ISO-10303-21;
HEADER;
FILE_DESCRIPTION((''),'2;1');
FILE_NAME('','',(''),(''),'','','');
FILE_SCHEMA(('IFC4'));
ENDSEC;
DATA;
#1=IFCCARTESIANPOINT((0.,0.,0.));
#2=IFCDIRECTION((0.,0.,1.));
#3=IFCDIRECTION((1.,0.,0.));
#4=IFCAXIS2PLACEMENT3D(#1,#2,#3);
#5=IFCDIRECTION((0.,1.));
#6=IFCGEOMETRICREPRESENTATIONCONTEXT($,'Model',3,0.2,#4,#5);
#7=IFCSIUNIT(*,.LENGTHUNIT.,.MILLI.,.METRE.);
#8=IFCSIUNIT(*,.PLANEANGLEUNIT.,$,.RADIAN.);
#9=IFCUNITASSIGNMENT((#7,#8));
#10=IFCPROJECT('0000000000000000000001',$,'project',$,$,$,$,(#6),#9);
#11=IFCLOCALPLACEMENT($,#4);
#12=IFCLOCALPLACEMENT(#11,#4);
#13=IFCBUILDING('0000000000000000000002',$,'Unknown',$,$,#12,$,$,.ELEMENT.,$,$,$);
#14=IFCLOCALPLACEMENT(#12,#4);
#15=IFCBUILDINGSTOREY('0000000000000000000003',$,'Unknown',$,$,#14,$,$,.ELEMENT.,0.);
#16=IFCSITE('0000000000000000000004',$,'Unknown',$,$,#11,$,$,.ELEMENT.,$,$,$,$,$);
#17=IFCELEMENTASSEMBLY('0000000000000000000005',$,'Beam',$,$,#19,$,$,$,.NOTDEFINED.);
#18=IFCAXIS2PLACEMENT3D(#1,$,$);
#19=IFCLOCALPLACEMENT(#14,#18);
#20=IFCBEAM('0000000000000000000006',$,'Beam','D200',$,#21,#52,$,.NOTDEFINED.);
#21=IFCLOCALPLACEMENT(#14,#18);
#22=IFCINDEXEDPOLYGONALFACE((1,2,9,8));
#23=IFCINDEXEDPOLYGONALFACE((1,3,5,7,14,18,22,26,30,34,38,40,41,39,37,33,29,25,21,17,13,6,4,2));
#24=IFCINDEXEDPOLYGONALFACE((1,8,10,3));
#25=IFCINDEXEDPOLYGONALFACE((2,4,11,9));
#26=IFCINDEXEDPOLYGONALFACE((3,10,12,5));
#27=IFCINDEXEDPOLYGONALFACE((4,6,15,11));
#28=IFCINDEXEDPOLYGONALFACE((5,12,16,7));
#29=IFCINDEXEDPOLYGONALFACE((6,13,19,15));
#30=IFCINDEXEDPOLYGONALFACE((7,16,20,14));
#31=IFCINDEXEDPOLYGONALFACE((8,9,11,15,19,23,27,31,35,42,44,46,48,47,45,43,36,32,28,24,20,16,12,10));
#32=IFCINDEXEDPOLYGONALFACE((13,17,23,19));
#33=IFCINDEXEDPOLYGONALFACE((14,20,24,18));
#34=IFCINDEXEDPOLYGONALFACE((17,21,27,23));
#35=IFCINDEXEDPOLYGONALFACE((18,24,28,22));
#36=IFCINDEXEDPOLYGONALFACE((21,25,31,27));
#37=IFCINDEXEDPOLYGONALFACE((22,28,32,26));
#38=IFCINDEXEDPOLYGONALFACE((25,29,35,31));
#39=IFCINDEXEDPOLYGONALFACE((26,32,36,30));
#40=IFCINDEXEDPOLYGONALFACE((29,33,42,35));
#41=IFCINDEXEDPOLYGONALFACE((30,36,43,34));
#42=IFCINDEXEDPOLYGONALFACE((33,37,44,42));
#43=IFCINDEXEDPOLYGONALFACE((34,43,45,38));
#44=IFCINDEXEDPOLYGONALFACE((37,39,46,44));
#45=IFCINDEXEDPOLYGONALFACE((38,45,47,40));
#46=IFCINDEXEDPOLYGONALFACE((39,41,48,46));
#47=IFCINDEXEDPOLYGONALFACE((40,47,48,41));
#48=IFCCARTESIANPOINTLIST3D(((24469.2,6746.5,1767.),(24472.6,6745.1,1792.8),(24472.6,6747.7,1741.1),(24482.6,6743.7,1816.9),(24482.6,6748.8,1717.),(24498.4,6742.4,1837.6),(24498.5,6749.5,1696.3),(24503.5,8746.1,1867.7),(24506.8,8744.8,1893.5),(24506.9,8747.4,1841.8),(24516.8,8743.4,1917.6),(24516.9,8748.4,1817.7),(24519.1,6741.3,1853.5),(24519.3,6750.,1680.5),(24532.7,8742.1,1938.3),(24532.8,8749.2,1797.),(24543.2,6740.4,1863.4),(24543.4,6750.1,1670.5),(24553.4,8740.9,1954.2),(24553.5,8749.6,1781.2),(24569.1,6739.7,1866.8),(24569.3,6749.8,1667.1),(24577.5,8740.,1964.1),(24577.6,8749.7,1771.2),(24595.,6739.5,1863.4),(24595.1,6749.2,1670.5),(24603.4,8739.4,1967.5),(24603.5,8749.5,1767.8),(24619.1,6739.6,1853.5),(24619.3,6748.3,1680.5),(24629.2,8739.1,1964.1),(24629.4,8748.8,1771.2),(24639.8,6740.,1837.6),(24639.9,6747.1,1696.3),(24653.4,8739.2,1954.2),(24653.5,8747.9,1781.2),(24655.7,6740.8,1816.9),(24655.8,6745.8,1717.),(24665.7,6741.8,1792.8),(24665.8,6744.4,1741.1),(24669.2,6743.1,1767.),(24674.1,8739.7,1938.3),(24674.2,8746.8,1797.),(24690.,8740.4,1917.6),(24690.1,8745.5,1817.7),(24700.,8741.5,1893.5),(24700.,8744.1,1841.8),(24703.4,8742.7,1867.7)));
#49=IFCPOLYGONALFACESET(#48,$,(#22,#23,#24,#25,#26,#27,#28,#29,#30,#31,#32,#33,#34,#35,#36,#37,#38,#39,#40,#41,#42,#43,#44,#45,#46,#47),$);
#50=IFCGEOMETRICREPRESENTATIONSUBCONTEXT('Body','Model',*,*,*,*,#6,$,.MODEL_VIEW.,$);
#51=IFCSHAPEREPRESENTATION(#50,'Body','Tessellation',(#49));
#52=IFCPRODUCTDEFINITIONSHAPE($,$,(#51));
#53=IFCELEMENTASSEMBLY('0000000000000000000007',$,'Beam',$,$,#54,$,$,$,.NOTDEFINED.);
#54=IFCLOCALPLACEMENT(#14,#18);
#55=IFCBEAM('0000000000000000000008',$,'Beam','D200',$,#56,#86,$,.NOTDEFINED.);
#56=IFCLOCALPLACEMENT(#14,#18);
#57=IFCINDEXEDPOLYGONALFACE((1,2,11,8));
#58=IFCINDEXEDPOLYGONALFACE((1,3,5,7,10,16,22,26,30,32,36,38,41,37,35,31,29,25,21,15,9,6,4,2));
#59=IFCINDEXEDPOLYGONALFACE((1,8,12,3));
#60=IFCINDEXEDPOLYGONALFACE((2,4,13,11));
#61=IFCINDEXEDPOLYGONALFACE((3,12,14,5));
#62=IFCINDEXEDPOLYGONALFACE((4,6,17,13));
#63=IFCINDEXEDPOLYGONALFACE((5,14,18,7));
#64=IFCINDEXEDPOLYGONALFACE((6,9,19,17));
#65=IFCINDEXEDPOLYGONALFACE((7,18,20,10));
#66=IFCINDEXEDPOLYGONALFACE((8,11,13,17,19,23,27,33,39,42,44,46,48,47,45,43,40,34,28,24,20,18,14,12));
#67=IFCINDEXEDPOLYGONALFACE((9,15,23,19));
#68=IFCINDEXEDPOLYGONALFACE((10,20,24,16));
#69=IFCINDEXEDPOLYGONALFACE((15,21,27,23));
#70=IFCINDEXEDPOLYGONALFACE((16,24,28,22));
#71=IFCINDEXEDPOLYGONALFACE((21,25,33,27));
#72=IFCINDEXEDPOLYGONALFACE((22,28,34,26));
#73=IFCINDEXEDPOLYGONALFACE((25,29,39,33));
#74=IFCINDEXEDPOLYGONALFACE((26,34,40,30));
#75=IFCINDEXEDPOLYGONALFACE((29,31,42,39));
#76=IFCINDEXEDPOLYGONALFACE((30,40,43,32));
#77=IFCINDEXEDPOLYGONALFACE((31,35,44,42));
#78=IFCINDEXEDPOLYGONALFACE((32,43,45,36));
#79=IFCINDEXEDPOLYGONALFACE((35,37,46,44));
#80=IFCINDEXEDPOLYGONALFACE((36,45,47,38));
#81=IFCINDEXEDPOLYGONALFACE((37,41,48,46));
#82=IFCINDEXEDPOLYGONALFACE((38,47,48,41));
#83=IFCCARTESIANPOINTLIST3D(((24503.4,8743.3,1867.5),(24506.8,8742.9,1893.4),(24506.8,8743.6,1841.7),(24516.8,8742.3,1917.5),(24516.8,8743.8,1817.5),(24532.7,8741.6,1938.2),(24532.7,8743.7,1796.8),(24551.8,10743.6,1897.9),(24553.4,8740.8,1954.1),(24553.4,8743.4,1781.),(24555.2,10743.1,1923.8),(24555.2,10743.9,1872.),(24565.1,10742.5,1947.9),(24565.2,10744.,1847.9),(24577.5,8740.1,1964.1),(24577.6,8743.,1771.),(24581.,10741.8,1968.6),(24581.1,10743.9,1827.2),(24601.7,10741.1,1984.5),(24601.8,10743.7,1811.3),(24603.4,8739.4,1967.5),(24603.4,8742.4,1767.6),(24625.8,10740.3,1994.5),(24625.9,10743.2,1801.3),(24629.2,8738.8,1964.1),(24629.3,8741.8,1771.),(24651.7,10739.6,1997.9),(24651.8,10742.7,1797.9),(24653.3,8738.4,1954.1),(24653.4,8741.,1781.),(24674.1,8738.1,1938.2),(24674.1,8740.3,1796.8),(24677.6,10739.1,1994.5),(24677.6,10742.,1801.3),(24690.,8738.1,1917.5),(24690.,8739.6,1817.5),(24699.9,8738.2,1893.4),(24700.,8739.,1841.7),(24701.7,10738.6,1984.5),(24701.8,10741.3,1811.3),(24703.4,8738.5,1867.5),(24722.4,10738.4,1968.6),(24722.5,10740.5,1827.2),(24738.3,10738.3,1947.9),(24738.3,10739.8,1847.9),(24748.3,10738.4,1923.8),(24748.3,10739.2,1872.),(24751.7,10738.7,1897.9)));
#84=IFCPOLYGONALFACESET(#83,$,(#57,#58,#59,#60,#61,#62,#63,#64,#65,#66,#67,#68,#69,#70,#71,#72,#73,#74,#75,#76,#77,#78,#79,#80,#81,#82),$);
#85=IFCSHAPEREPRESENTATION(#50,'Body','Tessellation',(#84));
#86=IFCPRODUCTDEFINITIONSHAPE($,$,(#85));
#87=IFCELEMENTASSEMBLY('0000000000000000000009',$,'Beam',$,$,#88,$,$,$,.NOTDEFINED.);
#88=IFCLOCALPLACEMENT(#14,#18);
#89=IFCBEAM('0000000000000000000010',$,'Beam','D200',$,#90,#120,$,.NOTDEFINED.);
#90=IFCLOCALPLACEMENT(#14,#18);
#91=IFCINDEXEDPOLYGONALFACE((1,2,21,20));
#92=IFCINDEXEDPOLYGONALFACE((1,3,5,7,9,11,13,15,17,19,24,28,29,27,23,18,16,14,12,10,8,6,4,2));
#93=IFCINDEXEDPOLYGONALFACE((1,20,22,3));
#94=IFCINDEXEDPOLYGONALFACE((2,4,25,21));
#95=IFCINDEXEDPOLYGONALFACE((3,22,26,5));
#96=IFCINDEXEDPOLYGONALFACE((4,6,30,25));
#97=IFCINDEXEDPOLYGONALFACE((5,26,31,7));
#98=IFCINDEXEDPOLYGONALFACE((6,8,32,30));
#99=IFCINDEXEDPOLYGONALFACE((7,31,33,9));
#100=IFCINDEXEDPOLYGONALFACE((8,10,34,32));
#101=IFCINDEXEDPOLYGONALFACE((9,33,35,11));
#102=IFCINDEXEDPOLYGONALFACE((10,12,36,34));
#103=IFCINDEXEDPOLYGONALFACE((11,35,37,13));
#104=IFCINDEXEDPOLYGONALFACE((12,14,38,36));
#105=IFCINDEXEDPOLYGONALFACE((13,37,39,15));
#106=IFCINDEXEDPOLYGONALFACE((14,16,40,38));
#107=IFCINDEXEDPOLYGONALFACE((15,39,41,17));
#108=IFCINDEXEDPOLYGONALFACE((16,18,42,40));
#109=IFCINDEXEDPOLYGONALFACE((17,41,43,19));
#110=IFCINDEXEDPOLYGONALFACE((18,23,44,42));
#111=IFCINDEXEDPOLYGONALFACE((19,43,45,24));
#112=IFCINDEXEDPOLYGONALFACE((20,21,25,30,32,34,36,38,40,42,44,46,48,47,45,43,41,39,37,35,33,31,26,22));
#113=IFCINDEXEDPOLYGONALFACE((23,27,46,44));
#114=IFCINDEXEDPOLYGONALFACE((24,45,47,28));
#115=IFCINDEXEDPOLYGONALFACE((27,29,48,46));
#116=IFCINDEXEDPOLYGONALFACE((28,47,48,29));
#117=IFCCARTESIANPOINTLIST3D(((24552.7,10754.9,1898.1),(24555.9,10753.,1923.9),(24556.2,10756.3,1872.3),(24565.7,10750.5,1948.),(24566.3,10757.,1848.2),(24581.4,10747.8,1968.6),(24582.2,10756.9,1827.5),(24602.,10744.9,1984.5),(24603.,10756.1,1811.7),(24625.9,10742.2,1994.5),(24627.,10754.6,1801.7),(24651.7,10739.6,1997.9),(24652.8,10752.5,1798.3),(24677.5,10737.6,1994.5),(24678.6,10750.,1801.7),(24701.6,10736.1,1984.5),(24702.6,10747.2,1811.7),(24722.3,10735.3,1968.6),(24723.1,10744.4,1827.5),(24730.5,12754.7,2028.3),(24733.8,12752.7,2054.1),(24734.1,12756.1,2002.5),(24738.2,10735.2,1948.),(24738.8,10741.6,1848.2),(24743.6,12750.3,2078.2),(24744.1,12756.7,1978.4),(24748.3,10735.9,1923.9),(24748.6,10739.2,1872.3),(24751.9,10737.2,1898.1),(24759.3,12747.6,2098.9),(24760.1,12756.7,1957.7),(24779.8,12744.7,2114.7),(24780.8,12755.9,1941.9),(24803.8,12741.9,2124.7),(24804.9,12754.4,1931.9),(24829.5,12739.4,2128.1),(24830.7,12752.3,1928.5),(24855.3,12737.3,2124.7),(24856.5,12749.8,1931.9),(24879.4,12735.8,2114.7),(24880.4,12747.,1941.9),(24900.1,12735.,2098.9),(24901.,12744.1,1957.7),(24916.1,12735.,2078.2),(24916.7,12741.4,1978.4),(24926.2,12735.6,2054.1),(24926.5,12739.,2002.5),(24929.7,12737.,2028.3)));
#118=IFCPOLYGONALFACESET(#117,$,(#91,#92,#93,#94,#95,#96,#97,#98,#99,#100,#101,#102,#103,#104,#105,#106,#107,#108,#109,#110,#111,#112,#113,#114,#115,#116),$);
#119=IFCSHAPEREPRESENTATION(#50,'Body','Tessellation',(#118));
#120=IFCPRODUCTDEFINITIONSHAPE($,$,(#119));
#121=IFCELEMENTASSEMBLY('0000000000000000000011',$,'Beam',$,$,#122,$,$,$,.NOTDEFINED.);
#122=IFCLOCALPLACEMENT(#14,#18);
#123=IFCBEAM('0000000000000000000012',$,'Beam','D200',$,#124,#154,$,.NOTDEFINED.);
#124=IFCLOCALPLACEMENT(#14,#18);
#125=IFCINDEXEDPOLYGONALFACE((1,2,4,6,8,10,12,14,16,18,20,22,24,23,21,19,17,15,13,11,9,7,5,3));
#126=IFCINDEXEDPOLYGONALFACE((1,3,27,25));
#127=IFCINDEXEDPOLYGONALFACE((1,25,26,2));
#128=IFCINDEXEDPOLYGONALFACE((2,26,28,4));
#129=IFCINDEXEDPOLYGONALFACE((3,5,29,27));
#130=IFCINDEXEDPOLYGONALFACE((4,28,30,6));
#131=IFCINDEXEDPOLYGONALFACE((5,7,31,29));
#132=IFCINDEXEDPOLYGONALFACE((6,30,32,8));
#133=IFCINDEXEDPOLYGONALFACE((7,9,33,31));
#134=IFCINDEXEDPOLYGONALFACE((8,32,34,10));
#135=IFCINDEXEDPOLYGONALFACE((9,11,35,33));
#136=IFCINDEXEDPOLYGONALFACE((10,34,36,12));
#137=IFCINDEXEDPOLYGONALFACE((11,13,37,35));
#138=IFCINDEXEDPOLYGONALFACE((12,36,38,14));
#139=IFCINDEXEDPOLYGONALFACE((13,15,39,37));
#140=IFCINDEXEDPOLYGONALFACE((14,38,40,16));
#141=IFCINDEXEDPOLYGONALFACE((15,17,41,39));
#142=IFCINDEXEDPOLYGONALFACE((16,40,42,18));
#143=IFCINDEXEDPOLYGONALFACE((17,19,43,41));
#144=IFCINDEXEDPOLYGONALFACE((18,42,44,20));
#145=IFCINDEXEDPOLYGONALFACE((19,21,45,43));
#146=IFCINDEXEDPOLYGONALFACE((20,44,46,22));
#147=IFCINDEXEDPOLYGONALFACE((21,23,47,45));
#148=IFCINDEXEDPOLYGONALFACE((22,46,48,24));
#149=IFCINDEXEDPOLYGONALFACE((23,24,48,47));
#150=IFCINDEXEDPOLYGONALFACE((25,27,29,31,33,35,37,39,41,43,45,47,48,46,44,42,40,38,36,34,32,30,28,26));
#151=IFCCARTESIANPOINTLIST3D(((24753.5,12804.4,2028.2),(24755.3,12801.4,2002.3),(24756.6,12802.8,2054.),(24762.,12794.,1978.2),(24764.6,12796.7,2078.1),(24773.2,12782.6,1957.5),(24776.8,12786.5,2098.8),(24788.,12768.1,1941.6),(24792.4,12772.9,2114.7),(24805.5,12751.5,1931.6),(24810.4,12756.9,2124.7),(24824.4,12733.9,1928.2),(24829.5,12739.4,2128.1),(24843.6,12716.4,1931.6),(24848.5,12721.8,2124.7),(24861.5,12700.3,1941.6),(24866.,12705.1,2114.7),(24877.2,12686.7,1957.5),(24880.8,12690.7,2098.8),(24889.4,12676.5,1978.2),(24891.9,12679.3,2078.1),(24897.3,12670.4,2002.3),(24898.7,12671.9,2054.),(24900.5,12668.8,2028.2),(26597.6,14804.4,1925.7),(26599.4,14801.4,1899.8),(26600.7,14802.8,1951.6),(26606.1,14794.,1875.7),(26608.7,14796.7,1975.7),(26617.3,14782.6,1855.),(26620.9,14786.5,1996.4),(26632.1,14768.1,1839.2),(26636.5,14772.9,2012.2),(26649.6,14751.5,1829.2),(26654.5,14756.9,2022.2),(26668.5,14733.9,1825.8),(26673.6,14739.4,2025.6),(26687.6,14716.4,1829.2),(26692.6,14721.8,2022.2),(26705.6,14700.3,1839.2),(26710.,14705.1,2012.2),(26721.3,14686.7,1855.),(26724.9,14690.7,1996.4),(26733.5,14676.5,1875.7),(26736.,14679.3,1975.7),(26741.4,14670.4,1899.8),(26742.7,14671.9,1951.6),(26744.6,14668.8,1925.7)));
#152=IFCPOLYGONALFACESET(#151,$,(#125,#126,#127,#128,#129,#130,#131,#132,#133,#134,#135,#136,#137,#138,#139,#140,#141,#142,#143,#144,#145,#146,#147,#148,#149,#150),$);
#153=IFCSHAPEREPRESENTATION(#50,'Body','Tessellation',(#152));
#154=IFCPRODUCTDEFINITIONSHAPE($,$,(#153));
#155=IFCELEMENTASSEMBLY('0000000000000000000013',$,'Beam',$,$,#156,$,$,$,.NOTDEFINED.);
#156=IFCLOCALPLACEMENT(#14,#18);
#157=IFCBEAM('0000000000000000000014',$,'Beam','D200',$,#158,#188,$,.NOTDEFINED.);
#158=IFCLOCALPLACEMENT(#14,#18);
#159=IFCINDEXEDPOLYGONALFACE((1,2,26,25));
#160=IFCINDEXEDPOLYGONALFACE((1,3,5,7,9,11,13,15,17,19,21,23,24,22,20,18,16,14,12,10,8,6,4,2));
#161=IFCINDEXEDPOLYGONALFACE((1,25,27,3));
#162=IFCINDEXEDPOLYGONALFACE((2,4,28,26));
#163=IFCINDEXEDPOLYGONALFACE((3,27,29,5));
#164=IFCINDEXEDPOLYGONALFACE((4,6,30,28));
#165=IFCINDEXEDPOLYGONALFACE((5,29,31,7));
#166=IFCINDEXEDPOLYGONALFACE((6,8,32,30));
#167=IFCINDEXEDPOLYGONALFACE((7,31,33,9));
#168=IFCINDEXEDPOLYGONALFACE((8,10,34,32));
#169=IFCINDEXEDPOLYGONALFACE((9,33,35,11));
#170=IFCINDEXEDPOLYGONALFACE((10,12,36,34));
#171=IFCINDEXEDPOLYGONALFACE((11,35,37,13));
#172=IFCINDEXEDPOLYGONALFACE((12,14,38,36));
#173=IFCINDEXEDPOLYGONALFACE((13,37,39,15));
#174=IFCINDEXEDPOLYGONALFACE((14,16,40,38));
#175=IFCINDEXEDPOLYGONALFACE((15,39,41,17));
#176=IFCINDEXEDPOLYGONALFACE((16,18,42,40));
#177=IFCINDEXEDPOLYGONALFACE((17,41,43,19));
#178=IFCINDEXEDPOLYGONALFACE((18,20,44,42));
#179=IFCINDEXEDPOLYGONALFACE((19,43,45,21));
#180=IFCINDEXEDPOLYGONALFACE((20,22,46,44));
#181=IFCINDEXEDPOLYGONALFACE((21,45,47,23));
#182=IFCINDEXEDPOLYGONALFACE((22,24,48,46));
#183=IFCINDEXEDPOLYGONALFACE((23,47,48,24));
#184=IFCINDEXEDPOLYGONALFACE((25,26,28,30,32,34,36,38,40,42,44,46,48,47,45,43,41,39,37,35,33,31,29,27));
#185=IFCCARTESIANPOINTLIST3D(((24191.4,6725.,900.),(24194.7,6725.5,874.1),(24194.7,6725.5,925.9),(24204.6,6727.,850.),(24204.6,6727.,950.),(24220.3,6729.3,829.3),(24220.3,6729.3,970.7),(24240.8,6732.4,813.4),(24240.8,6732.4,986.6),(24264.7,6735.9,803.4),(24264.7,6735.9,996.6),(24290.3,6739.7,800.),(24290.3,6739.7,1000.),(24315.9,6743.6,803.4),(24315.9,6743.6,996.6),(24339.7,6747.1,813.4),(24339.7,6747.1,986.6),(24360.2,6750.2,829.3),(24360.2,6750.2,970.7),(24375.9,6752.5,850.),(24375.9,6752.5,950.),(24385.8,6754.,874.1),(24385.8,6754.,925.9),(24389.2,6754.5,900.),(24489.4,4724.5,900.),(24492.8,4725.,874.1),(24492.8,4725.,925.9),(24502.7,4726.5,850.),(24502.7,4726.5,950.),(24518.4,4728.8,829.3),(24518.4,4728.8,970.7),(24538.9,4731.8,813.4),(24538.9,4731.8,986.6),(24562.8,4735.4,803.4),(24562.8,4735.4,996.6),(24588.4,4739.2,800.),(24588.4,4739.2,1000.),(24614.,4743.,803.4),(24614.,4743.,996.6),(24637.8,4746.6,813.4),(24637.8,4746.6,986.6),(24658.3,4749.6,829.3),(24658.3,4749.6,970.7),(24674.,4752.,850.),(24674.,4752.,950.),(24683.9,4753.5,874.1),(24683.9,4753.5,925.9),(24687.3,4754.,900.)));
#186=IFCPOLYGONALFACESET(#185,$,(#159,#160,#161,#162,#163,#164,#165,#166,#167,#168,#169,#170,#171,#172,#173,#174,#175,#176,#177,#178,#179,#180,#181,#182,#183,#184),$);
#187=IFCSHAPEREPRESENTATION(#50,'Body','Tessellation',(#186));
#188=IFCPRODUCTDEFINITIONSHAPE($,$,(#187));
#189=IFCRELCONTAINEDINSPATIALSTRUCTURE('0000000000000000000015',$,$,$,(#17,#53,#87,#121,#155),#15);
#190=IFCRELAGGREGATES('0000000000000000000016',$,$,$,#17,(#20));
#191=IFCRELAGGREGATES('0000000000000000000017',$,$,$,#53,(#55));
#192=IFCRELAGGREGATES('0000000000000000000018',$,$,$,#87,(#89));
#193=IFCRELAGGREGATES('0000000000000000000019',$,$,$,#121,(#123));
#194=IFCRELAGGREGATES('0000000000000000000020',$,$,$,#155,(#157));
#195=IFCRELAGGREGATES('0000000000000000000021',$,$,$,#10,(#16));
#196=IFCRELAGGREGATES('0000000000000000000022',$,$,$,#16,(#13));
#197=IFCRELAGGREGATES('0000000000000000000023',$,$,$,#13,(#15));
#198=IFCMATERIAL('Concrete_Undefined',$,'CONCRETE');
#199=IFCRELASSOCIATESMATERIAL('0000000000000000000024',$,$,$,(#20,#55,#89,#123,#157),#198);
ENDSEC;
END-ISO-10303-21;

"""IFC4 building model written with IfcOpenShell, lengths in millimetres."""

from ifc_helpers import new_model, si_unit, direction, frame, origin_with_axes, place, context, subcontext, project, spatial, line, indexed_curve, outline, extrude, material, element, aggregate, save


model = new_model("IFC4")

# Units and contexts
model_context = context("Model", 3, precision=0.2, world=origin_with_axes(), true_north=direction((0.0, 1.0)))
body_context = subcontext(model_context, "Body", "Model", "MODEL_VIEW")
ifc_project = project(units=[si_unit("LENGTHUNIT", "METRE", prefix="MILLI"), si_unit("PLANEANGLEUNIT", "RADIAN")], contexts=[model_context])

# Site, building, storey
site_placement = place(None, origin_with_axes())
site = spatial("IfcSite", under=ifc_project, at=site_placement, Name="Unknown", CompositionType="ELEMENT")
building_placement = place(site_placement, origin_with_axes())
building = spatial("IfcBuilding", under=site, at=building_placement, Name="Unknown", CompositionType="ELEMENT")
storey_placement = place(building_placement, origin_with_axes())
storey = spatial("IfcBuildingStorey", under=building, at=storey_placement, Name="Unknown", CompositionType="ELEMENT", Elevation=0.0)

# Shared definitions
ifc_material = material(Name="Concrete_Undefined", Category="CONCRETE")

# Element assemblies, beams
assembly_1_placement = place(storey_placement, frame((24603.4, 8744.4, 1867.7), z_axis=(-0.999853, 0.01713, 0.0), x_axis=(-0.017108, -0.998588, -0.050282)))
assembly_1 = element("IfcElementAssembly", 1, at=assembly_1_placement, inside=storey, Name="Beam", PredefinedType="NOTDEFINED")
beam_1_placement = place(assembly_1_placement, origin_with_axes())
beam_1 = element("IfcBeam", 2, at=beam_1_placement, material=ifc_material, Name="Beam", Description="D200", PredefinedType="NOTDEFINED", context=body_context, shape_type="SolidModel", body=[
    extrude(outline(indexed_curve([(100.0, 0.0), (96.6, 25.9), (86.6, 50.0), (70.7, 70.7), (50.0, 86.6), (25.9, 96.6), (0.0, 100.0), (-25.9, 96.6), (-50.0, 86.6), (-70.7, 70.7), (-86.6, 50.0), (-96.6, 25.9), (-100.0, 0.0), (-96.6, -25.9), (-86.6, -50.0), (-70.7, -70.7), (-50.0, -86.6), (-25.9, -96.6), (0.0, -100.0), (25.9, -96.6), (50.0, -86.6), (70.7, -70.7), (86.6, -50.0), (96.6, -25.9)], segments=[line(1, 2, 3, 4, 5, 6, 7, 8, 9, 10, 11, 12, 13, 14, 15, 16, 17, 18, 19, 20, 21, 22, 23, 24, 1)])), frame((0.0, 0.0, 0.0), z_axis=(-1.0, 0.0, 0.0), x_axis=(0.0, 0.0, 1.0)), (0.0, 0.0, -1.0), 2002.5),
])
aggregate(assembly_1, [beam_1])
assembly_2_placement = place(storey_placement, frame((24651.7, 10741.2, 1897.9), z_axis=(-0.999708, 0.024161, 0.0), x_axis=(-0.024158, -0.999593, -0.01516)))
assembly_2 = element("IfcElementAssembly", 3, at=assembly_2_placement, inside=storey, Name="Beam", PredefinedType="NOTDEFINED")
beam_2_placement = place(assembly_2_placement, origin_with_axes())
beam_2 = element("IfcBeam", 4, at=beam_2_placement, material=ifc_material, Name="Beam", Description="D200", PredefinedType="NOTDEFINED", context=body_context, shape_type="SolidModel", body=[
    extrude(outline(indexed_curve([(100.0, 0.0), (96.6, 25.9), (86.6, 50.0), (70.7, 70.7), (50.0, 86.6), (25.9, 96.6), (0.0, 100.0), (-25.9, 96.6), (-50.0, 86.6), (-70.7, 70.7), (-86.6, 50.0), (-96.6, 25.9), (-100.0, 0.0), (-96.6, -25.9), (-86.6, -50.0), (-70.7, -70.7), (-50.0, -86.6), (-25.9, -96.6), (0.0, -100.0), (25.9, -96.6), (50.0, -86.6), (70.7, -70.7), (86.6, -50.0), (96.6, -25.9)], segments=[line(1, 2, 3, 4, 5, 6, 7, 8, 9, 10, 11, 12, 13, 14, 15, 16, 17, 18, 19, 20, 21, 22, 23, 24, 1)])), frame((0.0, 0.0, 0.0), z_axis=(-1.0, 0.0, 0.0), x_axis=(0.0, 0.0, 1.0)), (0.0, 0.0, -1.0), 2001.1),
])
aggregate(assembly_2, [beam_2])
assembly_3_placement = place(storey_placement, frame((24830.1, 12745.8, 2028.3), z_axis=(-0.996069, 0.088583, 0.0), x_axis=(-0.088397, -0.99398, -0.064723)))
assembly_3 = element("IfcElementAssembly", 5, at=assembly_3_placement, inside=storey, Name="Beam", PredefinedType="NOTDEFINED")
beam_3_placement = place(assembly_3_placement, origin_with_axes())
beam_3 = element("IfcBeam", 6, at=beam_3_placement, material=ifc_material, Name="Beam", Description="D200", PredefinedType="NOTDEFINED", context=body_context, shape_type="SolidModel", body=[
    extrude(outline(indexed_curve([(100.0, 0.0), (96.6, 25.9), (86.6, 50.0), (70.7, 70.7), (50.0, 86.6), (25.9, 96.6), (0.0, 100.0), (-25.9, 96.6), (-50.0, 86.6), (-70.7, 70.7), (-86.6, 50.0), (-96.6, 25.9), (-100.0, 0.0), (-96.6, -25.9), (-86.6, -50.0), (-70.7, -70.7), (-50.0, -86.6), (-25.9, -96.6), (0.0, -100.0), (25.9, -96.6), (50.0, -86.6), (70.7, -70.7), (86.6, -50.0), (96.6, -25.9)], segments=[line(1, 2, 3, 4, 5, 6, 7, 8, 9, 10, 11, 12, 13, 14, 15, 16, 17, 18, 19, 20, 21, 22, 23, 24, 1)])), frame((0.0, 0.0, 0.0), z_axis=(-1.0, 0.0, 0.0), x_axis=(0.0, 0.0, 1.0)), (0.0, 0.0, -1.0), 2011.9),
])
aggregate(assembly_3, [beam_3])
assembly_4_placement = place(storey_placement, frame((26671.1, 14736.6, 1925.7), z_axis=(-0.735183, 0.677869, 0.0), x_axis=(-0.677389, -0.734662, 0.037633)))
assembly_4 = element("IfcElementAssembly", 7, at=assembly_4_placement, inside=storey, Name="Beam", PredefinedType="NOTDEFINED")
beam_4_placement = place(assembly_4_placement, origin_with_axes())
beam_4 = element("IfcBeam", 8, at=beam_4_placement, material=ifc_material, Name="Beam", Description="D200", PredefinedType="NOTDEFINED", context=body_context, shape_type="SolidModel", body=[
    extrude(outline(indexed_curve([(100.0, 0.0), (96.6, 25.9), (86.6, 50.0), (70.7, 70.7), (50.0, 86.6), (25.9, 96.6), (0.0, 100.0), (-25.9, 96.6), (-50.0, 86.6), (-70.7, 70.7), (-86.6, 50.0), (-96.6, 25.9), (-100.0, 0.0), (-96.6, -25.9), (-86.6, -50.0), (-70.7, -70.7), (-50.0, -86.6), (-25.9, -96.6), (0.0, -100.0), (25.9, -96.6), (50.0, -86.6), (70.7, -70.7), (86.6, -50.0), (96.6, -25.9)], segments=[line(1, 2, 3, 4, 5, 6, 7, 8, 9, 10, 11, 12, 13, 14, 15, 16, 17, 18, 19, 20, 21, 22, 23, 24, 1)])), frame((0.0, 0.0, 0.0), z_axis=(-1.0, 0.0, 0.0), x_axis=(0.0, 0.0, 1.0)), (0.0, 0.0, -1.0), 2722.3),
])
aggregate(assembly_4, [beam_4])
assembly_5_placement = place(storey_placement, frame((24290.3, 6739.7, 900.0), z_axis=(-0.989081, -0.14737, 0.0), x_axis=(0.14737, -0.989081, 0.0)))
assembly_5 = element("IfcElementAssembly", 9, at=assembly_5_placement, inside=storey, Name="Beam", PredefinedType="NOTDEFINED")
beam_5_placement = place(assembly_5_placement, origin_with_axes())
beam_5 = element("IfcBeam", 10, at=beam_5_placement, material=ifc_material, Name="Beam", Description="D200", PredefinedType="NOTDEFINED", context=body_context, shape_type="SolidModel", body=[
    extrude(outline(indexed_curve([(100.0, 0.0), (96.6, 25.9), (86.6, 50.0), (70.7, 70.7), (50.0, 86.6), (25.9, 96.6), (0.0, 100.0), (-25.9, 96.6), (-50.0, 86.6), (-70.7, 70.7), (-86.6, 50.0), (-96.6, 25.9), (-100.0, 0.0), (-96.6, -25.9), (-86.6, -50.0), (-70.7, -70.7), (-50.0, -86.6), (-25.9, -96.6), (0.0, -100.0), (25.9, -96.6), (50.0, -86.6), (70.7, -70.7), (86.6, -50.0), (96.6, -25.9)], segments=[line(1, 2, 3, 4, 5, 6, 7, 8, 9, 10, 11, 12, 13, 14, 15, 16, 17, 18, 19, 20, 21, 22, 23, 24, 1)])), frame((0.0, 0.0, 0.0), z_axis=(-1.0, 0.0, 0.0), x_axis=(0.0, 0.0, 1.0)), (0.0, 0.0, -1.0), 2022.6),
])
aggregate(assembly_5, [beam_5])

save(model, "model.ifc")
